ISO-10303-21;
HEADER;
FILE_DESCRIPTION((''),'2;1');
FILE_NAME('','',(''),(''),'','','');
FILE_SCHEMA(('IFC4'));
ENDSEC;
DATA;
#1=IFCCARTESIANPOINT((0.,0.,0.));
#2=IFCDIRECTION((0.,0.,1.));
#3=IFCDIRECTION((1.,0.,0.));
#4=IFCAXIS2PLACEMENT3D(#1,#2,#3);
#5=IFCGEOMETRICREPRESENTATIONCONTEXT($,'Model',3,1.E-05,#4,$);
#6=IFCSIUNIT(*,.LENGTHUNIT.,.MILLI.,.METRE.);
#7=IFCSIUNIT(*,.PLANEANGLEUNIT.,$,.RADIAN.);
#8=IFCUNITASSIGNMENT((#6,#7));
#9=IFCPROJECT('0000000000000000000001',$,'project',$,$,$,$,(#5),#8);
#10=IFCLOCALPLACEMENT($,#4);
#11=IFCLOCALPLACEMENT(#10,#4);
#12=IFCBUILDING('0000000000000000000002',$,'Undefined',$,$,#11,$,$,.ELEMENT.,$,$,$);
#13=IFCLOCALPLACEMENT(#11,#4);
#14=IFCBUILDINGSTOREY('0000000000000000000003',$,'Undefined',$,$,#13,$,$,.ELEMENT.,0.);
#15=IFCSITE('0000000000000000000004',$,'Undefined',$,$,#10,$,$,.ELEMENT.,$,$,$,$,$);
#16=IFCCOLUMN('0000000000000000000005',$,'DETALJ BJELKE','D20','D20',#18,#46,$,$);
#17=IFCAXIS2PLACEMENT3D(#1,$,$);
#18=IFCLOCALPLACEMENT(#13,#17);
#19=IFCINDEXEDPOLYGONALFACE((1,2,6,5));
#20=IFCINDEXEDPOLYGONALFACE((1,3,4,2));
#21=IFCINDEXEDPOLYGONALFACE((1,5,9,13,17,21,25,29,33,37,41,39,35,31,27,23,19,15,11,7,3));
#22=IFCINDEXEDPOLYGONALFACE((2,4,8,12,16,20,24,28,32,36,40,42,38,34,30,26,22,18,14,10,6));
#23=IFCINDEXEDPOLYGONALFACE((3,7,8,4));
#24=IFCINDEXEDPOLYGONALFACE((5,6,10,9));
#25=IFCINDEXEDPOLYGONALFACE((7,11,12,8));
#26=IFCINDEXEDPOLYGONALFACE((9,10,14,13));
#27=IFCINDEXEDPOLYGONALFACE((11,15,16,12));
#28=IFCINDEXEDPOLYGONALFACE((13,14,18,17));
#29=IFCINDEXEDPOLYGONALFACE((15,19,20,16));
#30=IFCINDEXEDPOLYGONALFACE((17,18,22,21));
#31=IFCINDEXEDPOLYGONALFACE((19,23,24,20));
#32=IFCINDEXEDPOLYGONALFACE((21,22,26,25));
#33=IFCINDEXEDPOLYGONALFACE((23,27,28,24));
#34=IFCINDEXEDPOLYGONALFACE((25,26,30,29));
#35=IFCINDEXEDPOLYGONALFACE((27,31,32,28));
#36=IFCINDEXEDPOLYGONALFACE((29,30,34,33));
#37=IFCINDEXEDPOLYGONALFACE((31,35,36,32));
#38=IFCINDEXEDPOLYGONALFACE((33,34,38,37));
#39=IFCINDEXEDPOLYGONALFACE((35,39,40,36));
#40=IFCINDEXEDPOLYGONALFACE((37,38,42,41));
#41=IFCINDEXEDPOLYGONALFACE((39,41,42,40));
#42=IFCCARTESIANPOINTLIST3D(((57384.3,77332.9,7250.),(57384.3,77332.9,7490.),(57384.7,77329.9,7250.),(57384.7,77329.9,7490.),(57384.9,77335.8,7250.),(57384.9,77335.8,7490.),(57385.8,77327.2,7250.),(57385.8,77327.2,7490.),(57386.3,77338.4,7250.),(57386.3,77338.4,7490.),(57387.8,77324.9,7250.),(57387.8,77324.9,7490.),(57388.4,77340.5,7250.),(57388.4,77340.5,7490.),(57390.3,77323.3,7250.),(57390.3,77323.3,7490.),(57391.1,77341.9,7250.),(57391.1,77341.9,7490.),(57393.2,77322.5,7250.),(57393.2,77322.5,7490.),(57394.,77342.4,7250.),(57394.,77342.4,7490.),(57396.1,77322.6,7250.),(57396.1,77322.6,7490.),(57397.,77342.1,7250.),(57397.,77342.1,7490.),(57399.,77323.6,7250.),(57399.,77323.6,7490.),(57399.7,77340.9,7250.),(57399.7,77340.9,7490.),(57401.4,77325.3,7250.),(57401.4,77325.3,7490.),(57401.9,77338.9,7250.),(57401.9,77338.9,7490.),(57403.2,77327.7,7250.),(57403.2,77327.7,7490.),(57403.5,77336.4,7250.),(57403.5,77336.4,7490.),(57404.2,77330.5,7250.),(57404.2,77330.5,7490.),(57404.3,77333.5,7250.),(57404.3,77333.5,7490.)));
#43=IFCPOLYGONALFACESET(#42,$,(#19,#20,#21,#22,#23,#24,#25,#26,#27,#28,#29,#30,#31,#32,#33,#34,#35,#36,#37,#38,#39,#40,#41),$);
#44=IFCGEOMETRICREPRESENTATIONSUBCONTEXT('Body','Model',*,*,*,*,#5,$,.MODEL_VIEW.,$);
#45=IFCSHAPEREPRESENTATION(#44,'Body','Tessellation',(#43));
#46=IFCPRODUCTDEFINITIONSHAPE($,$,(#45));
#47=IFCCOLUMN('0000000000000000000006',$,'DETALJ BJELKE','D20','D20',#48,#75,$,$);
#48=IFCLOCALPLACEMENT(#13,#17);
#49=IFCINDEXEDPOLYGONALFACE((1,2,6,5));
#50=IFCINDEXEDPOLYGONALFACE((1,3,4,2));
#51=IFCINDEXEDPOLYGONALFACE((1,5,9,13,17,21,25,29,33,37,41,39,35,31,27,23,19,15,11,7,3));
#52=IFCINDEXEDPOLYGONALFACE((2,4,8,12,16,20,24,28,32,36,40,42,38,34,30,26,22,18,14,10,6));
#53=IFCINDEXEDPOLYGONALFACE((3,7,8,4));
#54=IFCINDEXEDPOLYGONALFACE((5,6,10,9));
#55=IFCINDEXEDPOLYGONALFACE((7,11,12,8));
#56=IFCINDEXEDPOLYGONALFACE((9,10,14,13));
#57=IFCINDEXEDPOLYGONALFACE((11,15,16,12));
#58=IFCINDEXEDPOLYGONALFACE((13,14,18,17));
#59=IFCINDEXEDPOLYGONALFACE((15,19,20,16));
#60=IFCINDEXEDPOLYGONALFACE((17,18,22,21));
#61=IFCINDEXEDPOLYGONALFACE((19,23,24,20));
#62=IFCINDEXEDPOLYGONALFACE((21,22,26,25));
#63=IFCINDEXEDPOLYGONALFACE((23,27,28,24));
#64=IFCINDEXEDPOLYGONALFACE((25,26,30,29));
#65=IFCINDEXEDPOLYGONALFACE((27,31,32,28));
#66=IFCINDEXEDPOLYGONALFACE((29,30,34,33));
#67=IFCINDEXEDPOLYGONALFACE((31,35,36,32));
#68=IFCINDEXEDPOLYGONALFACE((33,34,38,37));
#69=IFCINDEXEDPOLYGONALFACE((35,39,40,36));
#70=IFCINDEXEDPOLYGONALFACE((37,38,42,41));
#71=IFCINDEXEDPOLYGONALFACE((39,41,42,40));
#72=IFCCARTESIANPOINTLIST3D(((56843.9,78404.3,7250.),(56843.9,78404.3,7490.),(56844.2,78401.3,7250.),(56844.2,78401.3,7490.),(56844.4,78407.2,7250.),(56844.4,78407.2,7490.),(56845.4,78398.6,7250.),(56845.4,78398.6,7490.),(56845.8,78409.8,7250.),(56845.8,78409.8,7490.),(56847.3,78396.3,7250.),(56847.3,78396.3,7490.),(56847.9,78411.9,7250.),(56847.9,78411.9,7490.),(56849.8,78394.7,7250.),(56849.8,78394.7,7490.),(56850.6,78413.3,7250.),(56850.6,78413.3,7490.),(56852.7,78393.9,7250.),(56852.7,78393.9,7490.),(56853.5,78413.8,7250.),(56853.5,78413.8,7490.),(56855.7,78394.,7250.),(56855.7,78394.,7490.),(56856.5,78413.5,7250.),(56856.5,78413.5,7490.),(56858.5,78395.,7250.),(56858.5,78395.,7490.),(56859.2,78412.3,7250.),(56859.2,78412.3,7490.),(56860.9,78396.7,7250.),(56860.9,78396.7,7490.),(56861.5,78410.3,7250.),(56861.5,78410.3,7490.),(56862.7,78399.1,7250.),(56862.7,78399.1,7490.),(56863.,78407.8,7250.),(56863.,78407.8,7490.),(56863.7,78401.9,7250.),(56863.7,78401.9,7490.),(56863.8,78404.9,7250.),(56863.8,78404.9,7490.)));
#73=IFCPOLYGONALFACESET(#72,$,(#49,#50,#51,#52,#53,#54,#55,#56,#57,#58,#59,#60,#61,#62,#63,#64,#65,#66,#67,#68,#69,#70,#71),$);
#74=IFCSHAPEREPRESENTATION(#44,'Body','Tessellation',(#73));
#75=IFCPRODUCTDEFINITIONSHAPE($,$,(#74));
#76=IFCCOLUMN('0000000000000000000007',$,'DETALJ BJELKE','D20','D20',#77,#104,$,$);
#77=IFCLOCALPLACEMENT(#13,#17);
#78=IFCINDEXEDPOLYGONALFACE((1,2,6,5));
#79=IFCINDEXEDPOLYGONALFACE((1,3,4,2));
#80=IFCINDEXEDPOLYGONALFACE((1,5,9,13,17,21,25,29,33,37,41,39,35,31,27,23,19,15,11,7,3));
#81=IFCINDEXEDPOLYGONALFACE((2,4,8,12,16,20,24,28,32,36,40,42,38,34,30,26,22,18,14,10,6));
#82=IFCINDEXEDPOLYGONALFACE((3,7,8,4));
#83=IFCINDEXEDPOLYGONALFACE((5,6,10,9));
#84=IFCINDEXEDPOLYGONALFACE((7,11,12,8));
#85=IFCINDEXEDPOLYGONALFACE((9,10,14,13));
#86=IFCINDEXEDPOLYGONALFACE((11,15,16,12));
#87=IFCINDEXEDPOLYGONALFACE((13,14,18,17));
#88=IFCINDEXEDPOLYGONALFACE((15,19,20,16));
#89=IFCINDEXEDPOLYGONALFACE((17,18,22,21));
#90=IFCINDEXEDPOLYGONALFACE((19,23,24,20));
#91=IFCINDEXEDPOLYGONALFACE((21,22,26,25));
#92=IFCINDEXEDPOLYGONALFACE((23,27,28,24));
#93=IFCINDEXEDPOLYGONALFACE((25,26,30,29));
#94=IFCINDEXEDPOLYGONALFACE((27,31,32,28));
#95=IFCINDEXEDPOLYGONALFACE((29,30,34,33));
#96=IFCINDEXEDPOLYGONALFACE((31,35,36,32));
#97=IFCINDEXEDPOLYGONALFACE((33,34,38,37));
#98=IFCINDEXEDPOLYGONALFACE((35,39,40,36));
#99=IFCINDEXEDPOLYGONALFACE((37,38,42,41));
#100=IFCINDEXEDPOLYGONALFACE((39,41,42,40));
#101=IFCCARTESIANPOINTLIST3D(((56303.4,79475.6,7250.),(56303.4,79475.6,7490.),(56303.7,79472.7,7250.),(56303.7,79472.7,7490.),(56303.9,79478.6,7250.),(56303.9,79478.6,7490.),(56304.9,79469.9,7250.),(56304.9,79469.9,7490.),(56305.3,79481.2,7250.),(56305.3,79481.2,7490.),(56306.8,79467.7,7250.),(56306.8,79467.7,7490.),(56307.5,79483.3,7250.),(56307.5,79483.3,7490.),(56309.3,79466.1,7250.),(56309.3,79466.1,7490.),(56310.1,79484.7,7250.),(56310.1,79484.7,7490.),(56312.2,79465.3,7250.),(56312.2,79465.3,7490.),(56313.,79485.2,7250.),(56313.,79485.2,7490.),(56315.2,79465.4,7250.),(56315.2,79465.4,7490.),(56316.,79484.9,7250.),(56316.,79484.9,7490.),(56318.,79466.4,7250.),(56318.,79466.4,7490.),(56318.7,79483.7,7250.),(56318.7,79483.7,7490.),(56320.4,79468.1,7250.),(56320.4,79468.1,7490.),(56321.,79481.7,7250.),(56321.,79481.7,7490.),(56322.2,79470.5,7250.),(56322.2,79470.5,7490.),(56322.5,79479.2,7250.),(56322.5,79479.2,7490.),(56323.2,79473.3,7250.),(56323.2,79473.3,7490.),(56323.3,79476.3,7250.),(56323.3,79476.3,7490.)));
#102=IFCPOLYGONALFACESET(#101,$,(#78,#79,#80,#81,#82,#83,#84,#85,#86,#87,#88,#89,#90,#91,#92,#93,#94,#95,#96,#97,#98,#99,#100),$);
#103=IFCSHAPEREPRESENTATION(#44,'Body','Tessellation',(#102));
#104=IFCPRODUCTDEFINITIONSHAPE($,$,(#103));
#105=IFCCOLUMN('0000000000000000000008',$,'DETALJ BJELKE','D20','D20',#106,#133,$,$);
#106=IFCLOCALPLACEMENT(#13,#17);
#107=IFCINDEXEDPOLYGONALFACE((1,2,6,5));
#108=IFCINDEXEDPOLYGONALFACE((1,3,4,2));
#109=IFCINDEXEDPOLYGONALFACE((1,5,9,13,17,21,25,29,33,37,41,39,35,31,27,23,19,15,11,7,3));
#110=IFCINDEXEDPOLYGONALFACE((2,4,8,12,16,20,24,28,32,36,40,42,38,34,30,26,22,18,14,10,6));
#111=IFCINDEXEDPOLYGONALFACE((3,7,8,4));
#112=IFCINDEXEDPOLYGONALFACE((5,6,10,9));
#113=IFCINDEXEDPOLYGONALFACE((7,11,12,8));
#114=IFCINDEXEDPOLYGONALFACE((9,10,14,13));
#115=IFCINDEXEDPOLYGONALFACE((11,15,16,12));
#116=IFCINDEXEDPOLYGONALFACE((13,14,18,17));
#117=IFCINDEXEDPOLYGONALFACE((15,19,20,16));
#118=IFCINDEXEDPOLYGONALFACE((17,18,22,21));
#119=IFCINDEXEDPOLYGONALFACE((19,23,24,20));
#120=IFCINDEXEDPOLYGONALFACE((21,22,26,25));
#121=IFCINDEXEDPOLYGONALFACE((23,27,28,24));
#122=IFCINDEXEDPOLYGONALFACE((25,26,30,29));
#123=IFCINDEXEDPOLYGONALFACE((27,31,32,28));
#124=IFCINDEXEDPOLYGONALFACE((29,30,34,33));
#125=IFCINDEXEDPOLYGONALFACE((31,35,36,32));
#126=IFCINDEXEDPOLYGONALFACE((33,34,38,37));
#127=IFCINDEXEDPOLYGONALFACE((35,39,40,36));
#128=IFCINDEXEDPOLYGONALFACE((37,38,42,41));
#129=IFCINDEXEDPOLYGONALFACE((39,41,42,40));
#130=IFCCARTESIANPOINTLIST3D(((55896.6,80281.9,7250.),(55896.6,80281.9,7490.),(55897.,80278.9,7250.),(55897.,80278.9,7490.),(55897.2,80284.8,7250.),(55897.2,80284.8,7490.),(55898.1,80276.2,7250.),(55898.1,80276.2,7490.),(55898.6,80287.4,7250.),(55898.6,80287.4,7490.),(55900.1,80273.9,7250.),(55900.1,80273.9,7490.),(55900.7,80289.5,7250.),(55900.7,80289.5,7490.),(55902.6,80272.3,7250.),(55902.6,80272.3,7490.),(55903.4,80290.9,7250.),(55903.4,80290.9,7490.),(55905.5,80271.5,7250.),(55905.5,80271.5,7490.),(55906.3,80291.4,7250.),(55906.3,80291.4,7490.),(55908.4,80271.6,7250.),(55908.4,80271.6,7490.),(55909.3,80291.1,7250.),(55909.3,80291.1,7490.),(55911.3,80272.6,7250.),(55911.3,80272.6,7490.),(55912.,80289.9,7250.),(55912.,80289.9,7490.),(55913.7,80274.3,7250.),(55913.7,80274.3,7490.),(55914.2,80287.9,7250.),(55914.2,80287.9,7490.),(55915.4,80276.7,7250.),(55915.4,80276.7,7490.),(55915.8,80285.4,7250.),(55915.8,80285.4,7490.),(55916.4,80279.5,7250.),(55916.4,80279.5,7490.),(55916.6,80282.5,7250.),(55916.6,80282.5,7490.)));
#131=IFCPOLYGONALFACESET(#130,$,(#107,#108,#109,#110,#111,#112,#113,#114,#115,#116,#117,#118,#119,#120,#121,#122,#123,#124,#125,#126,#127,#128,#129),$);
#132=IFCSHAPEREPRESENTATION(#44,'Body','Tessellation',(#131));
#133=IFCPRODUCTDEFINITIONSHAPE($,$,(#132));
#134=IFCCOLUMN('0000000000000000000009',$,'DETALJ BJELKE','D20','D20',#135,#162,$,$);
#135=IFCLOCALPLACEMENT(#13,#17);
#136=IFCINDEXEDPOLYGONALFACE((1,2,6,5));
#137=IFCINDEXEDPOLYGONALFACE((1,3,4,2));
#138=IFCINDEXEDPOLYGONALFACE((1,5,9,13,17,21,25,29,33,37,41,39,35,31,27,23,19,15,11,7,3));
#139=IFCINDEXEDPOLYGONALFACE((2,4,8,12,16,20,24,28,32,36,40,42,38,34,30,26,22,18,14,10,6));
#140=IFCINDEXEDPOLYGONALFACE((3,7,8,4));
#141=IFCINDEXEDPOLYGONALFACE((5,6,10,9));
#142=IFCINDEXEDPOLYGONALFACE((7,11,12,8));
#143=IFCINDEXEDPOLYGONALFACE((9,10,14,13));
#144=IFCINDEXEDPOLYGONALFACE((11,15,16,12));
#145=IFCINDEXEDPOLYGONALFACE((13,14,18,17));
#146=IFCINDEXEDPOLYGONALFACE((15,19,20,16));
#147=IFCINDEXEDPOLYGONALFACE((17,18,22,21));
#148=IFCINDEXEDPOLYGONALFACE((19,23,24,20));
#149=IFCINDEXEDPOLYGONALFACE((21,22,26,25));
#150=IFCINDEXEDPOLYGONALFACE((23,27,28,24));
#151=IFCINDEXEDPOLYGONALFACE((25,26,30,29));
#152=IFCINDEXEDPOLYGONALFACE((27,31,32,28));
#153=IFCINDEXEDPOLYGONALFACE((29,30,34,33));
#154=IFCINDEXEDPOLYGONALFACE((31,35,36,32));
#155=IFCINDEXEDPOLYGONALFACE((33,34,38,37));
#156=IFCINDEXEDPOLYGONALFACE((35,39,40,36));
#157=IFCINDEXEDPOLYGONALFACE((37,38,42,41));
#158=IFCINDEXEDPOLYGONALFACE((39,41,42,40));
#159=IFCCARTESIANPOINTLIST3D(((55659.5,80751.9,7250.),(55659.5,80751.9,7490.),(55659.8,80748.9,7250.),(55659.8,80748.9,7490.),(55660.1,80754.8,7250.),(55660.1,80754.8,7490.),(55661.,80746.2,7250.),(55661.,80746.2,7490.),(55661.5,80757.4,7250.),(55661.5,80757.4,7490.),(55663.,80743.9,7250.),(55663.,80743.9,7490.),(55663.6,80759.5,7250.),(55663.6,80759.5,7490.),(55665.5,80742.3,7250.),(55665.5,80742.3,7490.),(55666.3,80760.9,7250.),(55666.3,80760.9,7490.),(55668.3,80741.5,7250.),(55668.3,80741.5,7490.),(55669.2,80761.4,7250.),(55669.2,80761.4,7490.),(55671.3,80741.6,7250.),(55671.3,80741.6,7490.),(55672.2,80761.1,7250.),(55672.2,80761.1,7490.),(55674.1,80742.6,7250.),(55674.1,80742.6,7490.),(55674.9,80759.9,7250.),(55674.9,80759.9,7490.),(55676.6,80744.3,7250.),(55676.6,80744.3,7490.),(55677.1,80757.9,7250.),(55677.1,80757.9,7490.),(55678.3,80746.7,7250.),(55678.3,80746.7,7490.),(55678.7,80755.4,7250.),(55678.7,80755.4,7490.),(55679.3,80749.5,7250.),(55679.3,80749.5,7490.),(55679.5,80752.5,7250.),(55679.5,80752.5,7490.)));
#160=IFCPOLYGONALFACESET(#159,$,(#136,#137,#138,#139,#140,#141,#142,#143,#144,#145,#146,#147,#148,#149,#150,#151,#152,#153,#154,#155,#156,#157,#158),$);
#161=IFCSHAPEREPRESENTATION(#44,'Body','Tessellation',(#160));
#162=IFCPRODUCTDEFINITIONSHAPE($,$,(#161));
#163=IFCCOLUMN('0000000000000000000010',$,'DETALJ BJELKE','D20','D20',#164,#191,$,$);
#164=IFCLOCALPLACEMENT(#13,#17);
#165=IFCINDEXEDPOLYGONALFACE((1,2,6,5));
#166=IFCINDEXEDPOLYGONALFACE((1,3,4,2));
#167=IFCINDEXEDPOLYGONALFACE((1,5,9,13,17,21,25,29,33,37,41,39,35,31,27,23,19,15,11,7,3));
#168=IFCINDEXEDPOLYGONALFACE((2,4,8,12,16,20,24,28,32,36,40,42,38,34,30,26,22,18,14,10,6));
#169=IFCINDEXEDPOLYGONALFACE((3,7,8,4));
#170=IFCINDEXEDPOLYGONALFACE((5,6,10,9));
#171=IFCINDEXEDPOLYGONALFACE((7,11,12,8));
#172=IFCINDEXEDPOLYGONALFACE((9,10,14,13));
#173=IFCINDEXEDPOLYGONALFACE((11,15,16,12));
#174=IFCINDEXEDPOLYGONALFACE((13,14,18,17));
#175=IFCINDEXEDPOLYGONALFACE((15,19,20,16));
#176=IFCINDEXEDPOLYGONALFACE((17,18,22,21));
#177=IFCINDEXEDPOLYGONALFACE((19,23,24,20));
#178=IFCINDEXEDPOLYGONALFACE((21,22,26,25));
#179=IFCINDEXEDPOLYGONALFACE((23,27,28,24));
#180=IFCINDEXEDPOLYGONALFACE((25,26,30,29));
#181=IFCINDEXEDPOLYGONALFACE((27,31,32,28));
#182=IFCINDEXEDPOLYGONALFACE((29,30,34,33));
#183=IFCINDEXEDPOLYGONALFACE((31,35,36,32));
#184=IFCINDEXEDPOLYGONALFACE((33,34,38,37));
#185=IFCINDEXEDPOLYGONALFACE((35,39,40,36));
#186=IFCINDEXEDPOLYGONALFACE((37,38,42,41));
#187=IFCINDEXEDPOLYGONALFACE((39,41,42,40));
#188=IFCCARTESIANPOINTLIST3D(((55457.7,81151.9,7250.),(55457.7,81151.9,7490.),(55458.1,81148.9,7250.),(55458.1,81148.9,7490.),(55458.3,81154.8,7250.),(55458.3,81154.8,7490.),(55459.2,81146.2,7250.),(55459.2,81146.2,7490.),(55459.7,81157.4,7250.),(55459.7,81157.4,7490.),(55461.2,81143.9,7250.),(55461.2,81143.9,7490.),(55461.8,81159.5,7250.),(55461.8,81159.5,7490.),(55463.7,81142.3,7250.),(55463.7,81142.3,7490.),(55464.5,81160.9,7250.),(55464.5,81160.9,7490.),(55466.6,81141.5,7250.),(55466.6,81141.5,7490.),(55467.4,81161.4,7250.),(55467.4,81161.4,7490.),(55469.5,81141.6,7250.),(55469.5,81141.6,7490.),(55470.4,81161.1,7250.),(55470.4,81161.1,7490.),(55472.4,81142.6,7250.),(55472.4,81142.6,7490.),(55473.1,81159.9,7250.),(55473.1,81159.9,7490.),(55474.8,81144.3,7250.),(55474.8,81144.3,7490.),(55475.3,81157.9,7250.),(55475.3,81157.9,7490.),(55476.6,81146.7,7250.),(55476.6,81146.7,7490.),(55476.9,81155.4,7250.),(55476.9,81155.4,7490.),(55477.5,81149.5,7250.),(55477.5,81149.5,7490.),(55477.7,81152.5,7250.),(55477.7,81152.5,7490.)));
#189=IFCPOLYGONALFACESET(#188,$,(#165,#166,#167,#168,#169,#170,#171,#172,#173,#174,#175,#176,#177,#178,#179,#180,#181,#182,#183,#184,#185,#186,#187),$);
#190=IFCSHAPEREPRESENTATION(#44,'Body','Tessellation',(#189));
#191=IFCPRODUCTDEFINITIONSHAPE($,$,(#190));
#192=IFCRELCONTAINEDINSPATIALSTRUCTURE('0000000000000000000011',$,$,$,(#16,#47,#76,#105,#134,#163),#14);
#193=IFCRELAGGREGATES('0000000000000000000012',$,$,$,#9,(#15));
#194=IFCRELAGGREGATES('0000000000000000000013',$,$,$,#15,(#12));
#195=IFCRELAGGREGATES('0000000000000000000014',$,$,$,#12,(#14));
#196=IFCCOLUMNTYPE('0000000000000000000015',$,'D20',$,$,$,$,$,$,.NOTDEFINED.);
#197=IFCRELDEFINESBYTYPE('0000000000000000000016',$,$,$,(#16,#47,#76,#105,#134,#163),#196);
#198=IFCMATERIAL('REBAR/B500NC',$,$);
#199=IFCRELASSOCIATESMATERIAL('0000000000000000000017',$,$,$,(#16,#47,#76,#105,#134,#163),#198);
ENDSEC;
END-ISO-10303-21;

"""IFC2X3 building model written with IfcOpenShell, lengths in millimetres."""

from ifc_helpers import new_model, si_unit, frame, origin_with_axes, origin_2d_with_axis, place, context, subcontext, project, spatial, circle, extrude, material, type_object, element, save


model = new_model("IFC2X3")

# Units and contexts
model_context = context("Model", 3, precision=1e-05, world=origin_with_axes())
body_context = subcontext(model_context, "Body", "Model", "MODEL_VIEW")
ifc_project = project(units=[si_unit("LENGTHUNIT", "METRE", prefix="MILLI"), si_unit("PLANEANGLEUNIT", "RADIAN")], contexts=[model_context])

# Site, building, storey
site_placement = place(None, origin_with_axes())
site = spatial("IfcSite", under=ifc_project, at=site_placement, Name="Undefined", CompositionType="ELEMENT")
building_placement = place(site_placement, origin_with_axes())
building = spatial("IfcBuilding", under=site, at=building_placement, Name="Undefined", CompositionType="ELEMENT")
storey_placement = place(building_placement, origin_with_axes())
storey = spatial("IfcBuildingStorey", under=building, at=storey_placement, Name="Undefined", CompositionType="ELEMENT", Elevation=0.0)

# Columns
ifc_material_1 = material(Name="REBAR/B500NC")
column_type_1 = type_object("IfcColumnType", Name="D20", PredefinedType="NOTDEFINED")
for number, where, z_axis, x_axis, name in (
    (1, (57394.3, 77332.4, 7250.0), (0.0, 0.0, 1.0), (-0.886365, -0.462987, 0.0), "DETALJ BJELKE"),
    (2, (56853.8, 78403.8, 7250.0), (0.0, 0.0, 1.0), (-0.886365, -0.462987, 0.0), "DETALJ BJELKE"),
    (3, (56313.4, 79475.2, 7250.0), (0.0, 0.0, 1.0), (-0.886365, -0.462987, 0.0), "DETALJ BJELKE"),
    (4, (55906.6, 80281.4, 7250.0), (0.0, 0.0, 1.0), (-0.886365, -0.462987, 0.0), "DETALJ BJELKE"),
    (5, (55669.5, 80751.5, 7250.0), (0.0, 0.0, 1.0), (-0.886365, -0.462987, 0.0), "DETALJ BJELKE"),
    (6, (55467.7, 81151.4, 7250.0), (0.0, 0.0, 1.0), (-0.886365, -0.462987, 0.0), "DETALJ BJELKE"),
):
    element("IfcColumn", number, at=place(storey_placement, frame(where, z_axis=z_axis, x_axis=x_axis)), inside=storey, type_object=column_type_1, material=ifc_material_1, Name=name, Description="D20", ObjectType="D20", context=body_context, shape_type="SweptSolid", body=[
        extrude(circle(Radius=10.0, at=origin_2d_with_axis()), frame((0.0, 0.0, 240.0), z_axis=(0.0, 0.0, -1.0), x_axis=(0.0, 1.0, 0.0)), (0.0, 0.0, 1.0), 240.0),
    ])

save(model, "model.ifc")
